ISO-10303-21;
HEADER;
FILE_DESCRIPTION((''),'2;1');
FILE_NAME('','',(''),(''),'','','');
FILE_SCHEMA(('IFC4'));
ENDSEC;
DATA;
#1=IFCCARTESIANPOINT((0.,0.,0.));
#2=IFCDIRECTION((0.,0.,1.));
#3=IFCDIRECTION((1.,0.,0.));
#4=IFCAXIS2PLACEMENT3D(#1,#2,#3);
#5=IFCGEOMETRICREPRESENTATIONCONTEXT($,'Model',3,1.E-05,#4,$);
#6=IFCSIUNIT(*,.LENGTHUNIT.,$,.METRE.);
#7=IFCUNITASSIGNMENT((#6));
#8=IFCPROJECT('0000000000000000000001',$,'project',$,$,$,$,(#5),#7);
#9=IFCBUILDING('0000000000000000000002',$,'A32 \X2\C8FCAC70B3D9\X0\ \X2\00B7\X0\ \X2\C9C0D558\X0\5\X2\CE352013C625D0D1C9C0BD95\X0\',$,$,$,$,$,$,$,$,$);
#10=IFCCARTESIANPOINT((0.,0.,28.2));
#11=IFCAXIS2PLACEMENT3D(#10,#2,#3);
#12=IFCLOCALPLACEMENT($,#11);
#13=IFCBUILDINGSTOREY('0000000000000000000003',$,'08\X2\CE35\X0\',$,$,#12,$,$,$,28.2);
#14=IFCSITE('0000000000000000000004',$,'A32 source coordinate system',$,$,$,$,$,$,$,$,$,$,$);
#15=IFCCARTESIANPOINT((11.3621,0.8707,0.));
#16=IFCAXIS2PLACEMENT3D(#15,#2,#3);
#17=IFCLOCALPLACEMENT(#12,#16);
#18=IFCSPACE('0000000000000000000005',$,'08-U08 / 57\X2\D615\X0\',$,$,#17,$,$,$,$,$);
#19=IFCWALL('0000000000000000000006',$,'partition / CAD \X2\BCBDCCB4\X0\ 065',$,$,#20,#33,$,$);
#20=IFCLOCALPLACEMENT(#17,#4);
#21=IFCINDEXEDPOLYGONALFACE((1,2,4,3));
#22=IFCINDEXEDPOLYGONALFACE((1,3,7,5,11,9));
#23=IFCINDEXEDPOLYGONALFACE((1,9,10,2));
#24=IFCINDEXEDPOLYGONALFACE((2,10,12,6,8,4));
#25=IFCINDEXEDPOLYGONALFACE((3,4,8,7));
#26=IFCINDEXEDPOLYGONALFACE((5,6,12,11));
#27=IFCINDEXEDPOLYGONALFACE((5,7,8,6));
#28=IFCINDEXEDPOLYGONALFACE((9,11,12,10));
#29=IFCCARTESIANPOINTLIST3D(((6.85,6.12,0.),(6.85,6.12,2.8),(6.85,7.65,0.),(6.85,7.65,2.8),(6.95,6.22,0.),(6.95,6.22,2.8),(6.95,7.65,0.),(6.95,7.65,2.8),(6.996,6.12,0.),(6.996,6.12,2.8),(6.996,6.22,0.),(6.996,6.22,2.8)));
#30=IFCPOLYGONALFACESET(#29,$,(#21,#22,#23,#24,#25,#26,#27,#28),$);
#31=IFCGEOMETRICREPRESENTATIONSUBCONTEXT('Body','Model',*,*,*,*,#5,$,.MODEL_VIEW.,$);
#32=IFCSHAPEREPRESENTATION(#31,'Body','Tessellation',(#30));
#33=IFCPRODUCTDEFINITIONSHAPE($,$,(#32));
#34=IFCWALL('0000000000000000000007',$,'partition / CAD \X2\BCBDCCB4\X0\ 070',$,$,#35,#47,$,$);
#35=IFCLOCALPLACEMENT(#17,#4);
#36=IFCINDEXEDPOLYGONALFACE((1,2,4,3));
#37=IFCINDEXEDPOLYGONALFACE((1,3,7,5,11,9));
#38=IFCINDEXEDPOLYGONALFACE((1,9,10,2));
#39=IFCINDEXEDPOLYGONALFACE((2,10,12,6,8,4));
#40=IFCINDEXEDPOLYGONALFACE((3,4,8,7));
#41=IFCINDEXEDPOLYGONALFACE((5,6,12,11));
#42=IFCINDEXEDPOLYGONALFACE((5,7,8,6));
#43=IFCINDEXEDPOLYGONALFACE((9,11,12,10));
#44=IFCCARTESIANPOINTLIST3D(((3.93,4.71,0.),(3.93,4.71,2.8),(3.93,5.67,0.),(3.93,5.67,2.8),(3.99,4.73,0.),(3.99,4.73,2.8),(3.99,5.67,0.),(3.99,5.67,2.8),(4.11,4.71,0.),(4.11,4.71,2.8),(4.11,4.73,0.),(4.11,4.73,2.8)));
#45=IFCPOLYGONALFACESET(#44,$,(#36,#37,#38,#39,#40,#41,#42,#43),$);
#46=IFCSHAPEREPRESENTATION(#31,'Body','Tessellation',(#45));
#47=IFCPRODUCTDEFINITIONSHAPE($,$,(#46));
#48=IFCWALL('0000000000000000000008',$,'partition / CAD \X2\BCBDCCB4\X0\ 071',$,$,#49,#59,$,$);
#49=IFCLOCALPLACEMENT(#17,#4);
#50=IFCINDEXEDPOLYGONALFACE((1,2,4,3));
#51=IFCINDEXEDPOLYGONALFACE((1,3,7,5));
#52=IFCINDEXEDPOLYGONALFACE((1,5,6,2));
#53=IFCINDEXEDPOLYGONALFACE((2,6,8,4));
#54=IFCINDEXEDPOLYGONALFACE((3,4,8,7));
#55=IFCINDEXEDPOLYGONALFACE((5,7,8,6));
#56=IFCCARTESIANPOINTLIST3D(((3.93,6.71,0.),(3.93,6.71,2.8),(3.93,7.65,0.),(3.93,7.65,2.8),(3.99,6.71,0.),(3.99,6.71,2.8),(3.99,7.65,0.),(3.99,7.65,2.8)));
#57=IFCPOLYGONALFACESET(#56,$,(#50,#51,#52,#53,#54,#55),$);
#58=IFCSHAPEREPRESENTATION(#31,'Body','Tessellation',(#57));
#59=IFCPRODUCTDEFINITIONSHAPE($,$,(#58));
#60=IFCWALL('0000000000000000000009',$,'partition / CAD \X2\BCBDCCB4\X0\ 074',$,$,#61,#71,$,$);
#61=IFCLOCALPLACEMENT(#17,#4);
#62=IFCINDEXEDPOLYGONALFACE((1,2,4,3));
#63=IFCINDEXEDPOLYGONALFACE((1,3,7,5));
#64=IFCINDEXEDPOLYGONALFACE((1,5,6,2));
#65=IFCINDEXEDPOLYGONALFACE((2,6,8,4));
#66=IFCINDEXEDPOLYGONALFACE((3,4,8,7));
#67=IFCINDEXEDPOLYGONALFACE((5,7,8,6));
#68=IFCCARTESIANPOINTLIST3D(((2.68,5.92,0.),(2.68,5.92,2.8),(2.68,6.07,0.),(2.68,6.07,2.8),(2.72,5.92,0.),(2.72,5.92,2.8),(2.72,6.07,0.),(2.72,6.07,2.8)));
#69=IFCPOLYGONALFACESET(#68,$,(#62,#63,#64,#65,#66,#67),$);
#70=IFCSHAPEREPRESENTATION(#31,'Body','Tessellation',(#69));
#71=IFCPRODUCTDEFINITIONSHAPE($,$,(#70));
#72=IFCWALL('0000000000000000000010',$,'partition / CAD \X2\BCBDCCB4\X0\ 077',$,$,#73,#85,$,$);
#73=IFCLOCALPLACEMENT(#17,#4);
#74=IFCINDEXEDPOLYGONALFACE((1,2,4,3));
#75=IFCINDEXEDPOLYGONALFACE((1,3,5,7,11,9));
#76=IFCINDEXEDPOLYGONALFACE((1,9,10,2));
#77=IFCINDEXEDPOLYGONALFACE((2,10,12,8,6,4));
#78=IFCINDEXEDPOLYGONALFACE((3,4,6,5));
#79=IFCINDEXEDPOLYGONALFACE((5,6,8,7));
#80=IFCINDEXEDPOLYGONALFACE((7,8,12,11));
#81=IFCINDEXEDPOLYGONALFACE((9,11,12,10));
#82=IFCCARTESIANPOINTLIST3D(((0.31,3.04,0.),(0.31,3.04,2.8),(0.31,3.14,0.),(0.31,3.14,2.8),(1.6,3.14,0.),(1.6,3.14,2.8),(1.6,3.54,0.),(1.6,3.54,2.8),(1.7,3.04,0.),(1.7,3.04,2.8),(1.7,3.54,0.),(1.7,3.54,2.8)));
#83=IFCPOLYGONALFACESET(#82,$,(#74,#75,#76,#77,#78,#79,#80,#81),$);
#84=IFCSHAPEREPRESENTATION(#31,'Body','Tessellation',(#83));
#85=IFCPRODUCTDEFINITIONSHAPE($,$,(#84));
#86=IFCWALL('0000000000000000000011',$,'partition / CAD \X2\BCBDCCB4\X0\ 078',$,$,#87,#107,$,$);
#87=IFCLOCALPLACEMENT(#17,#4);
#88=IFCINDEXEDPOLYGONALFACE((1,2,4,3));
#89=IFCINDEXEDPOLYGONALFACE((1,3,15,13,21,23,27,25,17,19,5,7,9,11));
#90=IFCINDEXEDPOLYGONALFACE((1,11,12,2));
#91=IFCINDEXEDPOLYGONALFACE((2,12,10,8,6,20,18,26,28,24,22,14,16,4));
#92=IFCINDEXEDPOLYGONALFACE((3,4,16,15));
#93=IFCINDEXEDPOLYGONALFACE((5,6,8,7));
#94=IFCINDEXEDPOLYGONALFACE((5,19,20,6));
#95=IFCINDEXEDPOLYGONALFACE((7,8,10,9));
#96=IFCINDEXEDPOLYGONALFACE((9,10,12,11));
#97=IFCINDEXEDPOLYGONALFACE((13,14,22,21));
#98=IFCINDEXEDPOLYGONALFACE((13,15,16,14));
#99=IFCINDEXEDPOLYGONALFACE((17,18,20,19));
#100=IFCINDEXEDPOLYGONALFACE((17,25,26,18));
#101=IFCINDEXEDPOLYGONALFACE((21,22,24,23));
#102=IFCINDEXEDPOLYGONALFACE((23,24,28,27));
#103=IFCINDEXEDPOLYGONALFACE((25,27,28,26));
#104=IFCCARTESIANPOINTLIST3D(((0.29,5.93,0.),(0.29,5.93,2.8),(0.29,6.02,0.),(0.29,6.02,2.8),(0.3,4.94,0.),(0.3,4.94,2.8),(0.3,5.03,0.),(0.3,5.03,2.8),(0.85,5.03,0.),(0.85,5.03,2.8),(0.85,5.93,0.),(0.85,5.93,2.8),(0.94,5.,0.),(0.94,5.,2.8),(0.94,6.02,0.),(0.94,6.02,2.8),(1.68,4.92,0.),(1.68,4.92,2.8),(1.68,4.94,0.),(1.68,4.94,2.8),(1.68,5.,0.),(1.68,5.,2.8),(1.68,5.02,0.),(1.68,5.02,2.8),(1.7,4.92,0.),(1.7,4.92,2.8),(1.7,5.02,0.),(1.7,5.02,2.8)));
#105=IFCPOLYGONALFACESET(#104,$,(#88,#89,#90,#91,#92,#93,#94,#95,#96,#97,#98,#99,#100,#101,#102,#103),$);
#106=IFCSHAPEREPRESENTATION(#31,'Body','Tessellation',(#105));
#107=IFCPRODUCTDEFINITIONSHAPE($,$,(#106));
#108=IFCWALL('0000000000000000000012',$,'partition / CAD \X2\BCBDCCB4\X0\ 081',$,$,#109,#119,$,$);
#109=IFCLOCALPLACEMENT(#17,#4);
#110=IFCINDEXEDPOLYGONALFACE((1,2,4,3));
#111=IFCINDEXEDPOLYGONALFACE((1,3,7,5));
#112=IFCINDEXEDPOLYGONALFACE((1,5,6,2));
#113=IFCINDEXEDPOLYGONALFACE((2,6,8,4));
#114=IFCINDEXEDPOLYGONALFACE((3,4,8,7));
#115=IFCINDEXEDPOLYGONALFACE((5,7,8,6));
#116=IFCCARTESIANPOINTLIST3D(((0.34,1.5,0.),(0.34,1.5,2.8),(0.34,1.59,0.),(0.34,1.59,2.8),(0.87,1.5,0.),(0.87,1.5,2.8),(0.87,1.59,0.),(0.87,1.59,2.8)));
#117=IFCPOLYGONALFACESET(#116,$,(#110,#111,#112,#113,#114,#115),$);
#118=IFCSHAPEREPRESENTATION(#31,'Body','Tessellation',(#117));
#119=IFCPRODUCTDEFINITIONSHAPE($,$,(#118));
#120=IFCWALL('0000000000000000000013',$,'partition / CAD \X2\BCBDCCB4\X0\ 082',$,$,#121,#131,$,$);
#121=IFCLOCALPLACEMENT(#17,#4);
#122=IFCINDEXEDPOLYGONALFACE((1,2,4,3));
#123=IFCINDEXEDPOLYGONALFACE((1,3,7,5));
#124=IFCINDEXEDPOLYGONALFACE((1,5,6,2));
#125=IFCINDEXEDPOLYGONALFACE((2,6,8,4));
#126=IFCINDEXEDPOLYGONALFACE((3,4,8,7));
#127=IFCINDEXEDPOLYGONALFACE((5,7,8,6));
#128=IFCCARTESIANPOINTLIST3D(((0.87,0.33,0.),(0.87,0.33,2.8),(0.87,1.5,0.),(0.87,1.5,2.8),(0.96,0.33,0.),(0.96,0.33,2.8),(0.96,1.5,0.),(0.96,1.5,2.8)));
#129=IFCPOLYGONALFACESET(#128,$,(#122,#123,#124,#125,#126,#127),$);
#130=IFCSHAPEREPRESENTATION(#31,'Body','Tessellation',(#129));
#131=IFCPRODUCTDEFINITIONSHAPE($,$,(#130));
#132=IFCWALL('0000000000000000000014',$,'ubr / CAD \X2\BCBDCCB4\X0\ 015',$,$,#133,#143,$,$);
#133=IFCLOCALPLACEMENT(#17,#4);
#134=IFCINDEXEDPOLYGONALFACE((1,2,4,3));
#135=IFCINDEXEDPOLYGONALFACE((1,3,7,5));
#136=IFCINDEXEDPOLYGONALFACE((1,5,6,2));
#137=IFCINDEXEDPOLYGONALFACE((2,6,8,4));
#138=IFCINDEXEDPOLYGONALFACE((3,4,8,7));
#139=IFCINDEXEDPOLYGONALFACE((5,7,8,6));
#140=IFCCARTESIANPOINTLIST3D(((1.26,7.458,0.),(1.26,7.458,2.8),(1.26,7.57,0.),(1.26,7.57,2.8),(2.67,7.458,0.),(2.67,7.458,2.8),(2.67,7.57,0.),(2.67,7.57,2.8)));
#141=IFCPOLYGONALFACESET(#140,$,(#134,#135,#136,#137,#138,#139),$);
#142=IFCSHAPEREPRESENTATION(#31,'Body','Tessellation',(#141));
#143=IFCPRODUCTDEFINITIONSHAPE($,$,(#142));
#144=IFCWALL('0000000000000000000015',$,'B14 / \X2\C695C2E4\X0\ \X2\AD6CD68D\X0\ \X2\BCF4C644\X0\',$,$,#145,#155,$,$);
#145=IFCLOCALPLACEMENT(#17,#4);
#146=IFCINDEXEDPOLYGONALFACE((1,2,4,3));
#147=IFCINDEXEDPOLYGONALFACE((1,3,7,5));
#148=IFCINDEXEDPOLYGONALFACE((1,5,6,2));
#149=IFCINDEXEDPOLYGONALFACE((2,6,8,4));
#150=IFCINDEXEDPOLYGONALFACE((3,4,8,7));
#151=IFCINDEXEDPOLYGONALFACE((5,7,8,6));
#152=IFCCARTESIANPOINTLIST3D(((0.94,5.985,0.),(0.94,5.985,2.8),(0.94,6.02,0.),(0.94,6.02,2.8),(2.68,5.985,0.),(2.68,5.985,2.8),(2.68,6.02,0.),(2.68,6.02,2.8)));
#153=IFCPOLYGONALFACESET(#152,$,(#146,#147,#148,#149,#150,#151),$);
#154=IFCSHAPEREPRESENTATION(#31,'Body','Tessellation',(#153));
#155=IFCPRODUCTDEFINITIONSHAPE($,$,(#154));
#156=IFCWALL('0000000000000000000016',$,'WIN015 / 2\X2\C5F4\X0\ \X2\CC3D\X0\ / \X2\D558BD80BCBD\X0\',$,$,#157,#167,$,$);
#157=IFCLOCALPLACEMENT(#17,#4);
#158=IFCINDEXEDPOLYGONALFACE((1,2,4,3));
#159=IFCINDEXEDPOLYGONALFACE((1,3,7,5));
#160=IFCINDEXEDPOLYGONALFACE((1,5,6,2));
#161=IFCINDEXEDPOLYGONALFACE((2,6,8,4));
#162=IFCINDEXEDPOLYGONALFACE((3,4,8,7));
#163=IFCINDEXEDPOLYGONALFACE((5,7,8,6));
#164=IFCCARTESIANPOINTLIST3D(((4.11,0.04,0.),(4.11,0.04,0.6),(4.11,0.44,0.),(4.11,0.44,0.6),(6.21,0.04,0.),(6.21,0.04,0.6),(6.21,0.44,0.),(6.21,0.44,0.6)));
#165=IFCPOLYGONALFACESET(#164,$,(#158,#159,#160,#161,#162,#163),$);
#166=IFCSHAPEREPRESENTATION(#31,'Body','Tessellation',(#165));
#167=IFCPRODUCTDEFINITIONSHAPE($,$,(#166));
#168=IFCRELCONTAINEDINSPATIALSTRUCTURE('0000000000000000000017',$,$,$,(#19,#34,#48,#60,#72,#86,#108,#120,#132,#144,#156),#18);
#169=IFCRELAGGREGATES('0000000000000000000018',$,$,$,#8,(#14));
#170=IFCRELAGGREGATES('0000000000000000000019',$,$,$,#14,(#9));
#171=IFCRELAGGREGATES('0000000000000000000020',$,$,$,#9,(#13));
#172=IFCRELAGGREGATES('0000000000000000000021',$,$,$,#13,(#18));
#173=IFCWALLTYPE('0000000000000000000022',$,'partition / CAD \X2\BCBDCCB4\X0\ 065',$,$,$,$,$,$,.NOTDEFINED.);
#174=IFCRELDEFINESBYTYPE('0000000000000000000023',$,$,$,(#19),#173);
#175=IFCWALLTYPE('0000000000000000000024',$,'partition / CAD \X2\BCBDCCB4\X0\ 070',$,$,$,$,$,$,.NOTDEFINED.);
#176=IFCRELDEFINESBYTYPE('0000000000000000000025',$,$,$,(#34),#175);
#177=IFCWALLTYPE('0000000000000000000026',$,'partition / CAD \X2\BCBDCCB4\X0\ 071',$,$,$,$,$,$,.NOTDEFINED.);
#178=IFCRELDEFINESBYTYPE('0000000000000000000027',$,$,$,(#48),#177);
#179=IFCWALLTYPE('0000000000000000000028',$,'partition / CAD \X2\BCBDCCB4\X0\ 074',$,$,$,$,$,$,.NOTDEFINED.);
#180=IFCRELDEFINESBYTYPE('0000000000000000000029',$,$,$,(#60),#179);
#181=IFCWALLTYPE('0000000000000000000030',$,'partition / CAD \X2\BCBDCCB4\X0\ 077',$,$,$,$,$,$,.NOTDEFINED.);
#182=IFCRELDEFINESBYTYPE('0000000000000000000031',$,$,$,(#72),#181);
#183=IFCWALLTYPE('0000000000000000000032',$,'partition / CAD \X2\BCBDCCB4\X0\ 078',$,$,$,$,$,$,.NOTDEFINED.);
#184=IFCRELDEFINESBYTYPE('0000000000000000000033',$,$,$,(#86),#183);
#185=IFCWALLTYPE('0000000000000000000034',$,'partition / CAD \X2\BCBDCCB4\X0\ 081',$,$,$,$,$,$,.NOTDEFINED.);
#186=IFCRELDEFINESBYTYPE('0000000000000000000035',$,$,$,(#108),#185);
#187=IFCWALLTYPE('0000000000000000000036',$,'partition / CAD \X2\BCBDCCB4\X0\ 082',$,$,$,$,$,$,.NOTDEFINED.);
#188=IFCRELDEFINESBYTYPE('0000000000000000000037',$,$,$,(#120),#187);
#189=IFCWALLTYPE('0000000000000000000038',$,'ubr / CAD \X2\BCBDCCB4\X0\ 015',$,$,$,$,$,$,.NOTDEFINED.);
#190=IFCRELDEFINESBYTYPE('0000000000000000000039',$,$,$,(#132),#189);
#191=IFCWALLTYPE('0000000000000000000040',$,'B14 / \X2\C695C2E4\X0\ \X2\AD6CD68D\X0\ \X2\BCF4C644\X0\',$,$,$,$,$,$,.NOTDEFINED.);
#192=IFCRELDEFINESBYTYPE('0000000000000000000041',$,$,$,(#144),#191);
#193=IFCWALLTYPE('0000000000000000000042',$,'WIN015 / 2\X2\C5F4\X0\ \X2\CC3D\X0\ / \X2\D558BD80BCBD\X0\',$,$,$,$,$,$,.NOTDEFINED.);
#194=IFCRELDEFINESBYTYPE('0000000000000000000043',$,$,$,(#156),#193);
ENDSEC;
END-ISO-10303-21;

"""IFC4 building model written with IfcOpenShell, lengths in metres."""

from ifc_helpers import new_model, si_unit, frame, origin, origin_with_axes, place, context, subcontext, project, spatial, polyline, outline, extrude, source, transform, mapped, type_object, type_shapes, element, save


model = new_model("IFC4")

# Units and contexts
model_context = context("Model", 3, precision=1e-05, world=origin_with_axes())
body_context = subcontext(model_context, "Body", "Model", "MODEL_VIEW")
ifc_project = project(units=[si_unit("LENGTHUNIT", "METRE")], contexts=[model_context])

# Site, building, storey, space
storey_placement = place(None, frame((0.0, 0.0, 28.2), z_axis=(0.0, 0.0, 1.0), x_axis=(1.0, 0.0, 0.0)))
space_placement = place(storey_placement, frame((11.3621, 0.8707, 0.0), z_axis=(0.0, 0.0, 1.0), x_axis=(1.0, 0.0, 0.0)))
site = spatial("IfcSite", under=ifc_project, Name="A32 source coordinate system")
building = spatial("IfcBuilding", under=site, Name="A32 주거동 · 지하5층–옥탑지붕")
storey = spatial("IfcBuildingStorey", under=building, at=storey_placement, Name="08층", Elevation=28.2)
space = spatial("IfcSpace", under=storey, at=space_placement, Name="08-U08 / 57형")

# Walls
wall_type_1 = type_object("IfcWallType", Name="partition / CAD 벽체 065", PredefinedType="NOTDEFINED")
shared_shape_1 = source(origin(), body_context, "Body", "SweptSolid", [
    extrude(outline(polyline([(6.95, 7.65), (6.95, 6.22), (6.996, 6.22), (6.996, 6.12), (6.85, 6.12), (6.85, 7.65), (6.95, 7.65)])), origin(), (0.0, 0.0, 1.0), 2.8),
])
type_shapes(wall_type_1, [shared_shape_1])
wall_1_placement = place(space_placement, origin_with_axes())
element("IfcWall", 1, at=wall_1_placement, inside=space, type_object=wall_type_1, Name="partition / CAD 벽체 065", context=body_context, shape_type="MappedRepresentation", body=[
    mapped(shared_shape_1, transform((0.0, 0.0, 0.0), scale=1.0)),
])
wall_type_2 = type_object("IfcWallType", Name="partition / CAD 벽체 070", PredefinedType="NOTDEFINED")
shared_shape_2 = source(origin(), body_context, "Body", "SweptSolid", [
    extrude(outline(polyline([(4.11, 4.73), (4.11, 4.71), (3.93, 4.71), (3.93, 5.67), (3.99, 5.67), (3.99, 4.73), (4.11, 4.73)])), origin(), (0.0, 0.0, 1.0), 2.8),
])
type_shapes(wall_type_2, [shared_shape_2])
wall_2_placement = place(space_placement, origin_with_axes())
element("IfcWall", 2, at=wall_2_placement, inside=space, type_object=wall_type_2, Name="partition / CAD 벽체 070", context=body_context, shape_type="MappedRepresentation", body=[
    mapped(shared_shape_2, transform((0.0, 0.0, 0.0), scale=1.0)),
])
wall_type_3 = type_object("IfcWallType", Name="partition / CAD 벽체 071", PredefinedType="NOTDEFINED")
shared_shape_3 = source(origin(), body_context, "Body", "SweptSolid", [
    extrude(outline(polyline([(3.93, 6.71), (3.93, 7.65), (3.99, 7.65), (3.99, 6.71), (3.93, 6.71)])), origin(), (0.0, 0.0, 1.0), 2.8),
])
type_shapes(wall_type_3, [shared_shape_3])
wall_3_placement = place(space_placement, origin_with_axes())
element("IfcWall", 3, at=wall_3_placement, inside=space, type_object=wall_type_3, Name="partition / CAD 벽체 071", context=body_context, shape_type="MappedRepresentation", body=[
    mapped(shared_shape_3, transform((0.0, 0.0, 0.0), scale=1.0)),
])
wall_type_4 = type_object("IfcWallType", Name="partition / CAD 벽체 074", PredefinedType="NOTDEFINED")
shared_shape_4 = source(origin(), body_context, "Body", "SweptSolid", [
    extrude(outline(polyline([(2.72, 6.07), (2.72, 5.92), (2.68, 5.92), (2.68, 6.07), (2.72, 6.07)])), origin(), (0.0, 0.0, 1.0), 2.8),
])
type_shapes(wall_type_4, [shared_shape_4])
wall_4_placement = place(space_placement, origin_with_axes())
element("IfcWall", 4, at=wall_4_placement, inside=space, type_object=wall_type_4, Name="partition / CAD 벽체 074", context=body_context, shape_type="MappedRepresentation", body=[
    mapped(shared_shape_4, transform((0.0, 0.0, 0.0), scale=1.0)),
])
wall_type_5 = type_object("IfcWallType", Name="partition / CAD 벽체 077", PredefinedType="NOTDEFINED")
shared_shape_5 = source(origin(), body_context, "Body", "SweptSolid", [
    extrude(outline(polyline([(1.7, 3.54), (1.7, 3.04), (0.31, 3.04), (0.31, 3.14), (1.6, 3.14), (1.6, 3.54), (1.7, 3.54)])), origin(), (0.0, 0.0, 1.0), 2.8),
])
type_shapes(wall_type_5, [shared_shape_5])
wall_5_placement = place(space_placement, origin_with_axes())
element("IfcWall", 5, at=wall_5_placement, inside=space, type_object=wall_type_5, Name="partition / CAD 벽체 077", context=body_context, shape_type="MappedRepresentation", body=[
    mapped(shared_shape_5, transform((0.0, 0.0, 0.0), scale=1.0)),
])
wall_type_6 = type_object("IfcWallType", Name="partition / CAD 벽체 078", PredefinedType="NOTDEFINED")
shared_shape_6 = source(origin(), body_context, "Body", "SweptSolid", [
    extrude(outline(polyline([(1.7, 4.92), (1.68, 4.92), (1.68, 4.94), (0.3, 4.94), (0.3, 5.03), (0.85, 5.03), (0.85, 5.93), (0.29, 5.93), (0.29, 6.02), (0.94, 6.02), (0.94, 5.0), (1.68, 5.0), (1.68, 5.02), (1.7, 5.02), (1.7, 4.92)])), origin(), (0.0, 0.0, 1.0), 2.8),
])
type_shapes(wall_type_6, [shared_shape_6])
wall_6_placement = place(space_placement, origin_with_axes())
element("IfcWall", 6, at=wall_6_placement, inside=space, type_object=wall_type_6, Name="partition / CAD 벽체 078", context=body_context, shape_type="MappedRepresentation", body=[
    mapped(shared_shape_6, transform((0.0, 0.0, 0.0), scale=1.0)),
])
wall_type_7 = type_object("IfcWallType", Name="partition / CAD 벽체 081", PredefinedType="NOTDEFINED")
shared_shape_7 = source(origin(), body_context, "Body", "SweptSolid", [
    extrude(outline(polyline([(0.34, 1.59), (0.87, 1.59), (0.87, 1.5), (0.34, 1.5), (0.34, 1.59)])), origin(), (0.0, 0.0, 1.0), 2.8),
])
type_shapes(wall_type_7, [shared_shape_7])
wall_7_placement = place(space_placement, origin_with_axes())
element("IfcWall", 7, at=wall_7_placement, inside=space, type_object=wall_type_7, Name="partition / CAD 벽체 081", context=body_context, shape_type="MappedRepresentation", body=[
    mapped(shared_shape_7, transform((0.0, 0.0, 0.0), scale=1.0)),
])
wall_type_8 = type_object("IfcWallType", Name="partition / CAD 벽체 082", PredefinedType="NOTDEFINED")
shared_shape_8 = source(origin(), body_context, "Body", "SweptSolid", [
    extrude(outline(polyline([(0.96, 0.33), (0.87, 0.33), (0.87, 1.5), (0.96, 1.5), (0.96, 0.33)])), origin(), (0.0, 0.0, 1.0), 2.8),
])
type_shapes(wall_type_8, [shared_shape_8])
wall_8_placement = place(space_placement, origin_with_axes())
element("IfcWall", 8, at=wall_8_placement, inside=space, type_object=wall_type_8, Name="partition / CAD 벽체 082", context=body_context, shape_type="MappedRepresentation", body=[
    mapped(shared_shape_8, transform((0.0, 0.0, 0.0), scale=1.0)),
])
wall_type_9 = type_object("IfcWallType", Name="ubr / CAD 벽체 015", PredefinedType="NOTDEFINED")
shared_shape_9 = source(origin(), body_context, "Body", "SweptSolid", [
    extrude(outline(polyline([(2.67, 7.57), (2.67, 7.458), (1.26, 7.458), (1.26, 7.57), (2.67, 7.57)])), origin(), (0.0, 0.0, 1.0), 2.8),
])
type_shapes(wall_type_9, [shared_shape_9])
wall_9_placement = place(space_placement, origin_with_axes())
element("IfcWall", 9, at=wall_9_placement, inside=space, type_object=wall_type_9, Name="ubr / CAD 벽체 015", context=body_context, shape_type="MappedRepresentation", body=[
    mapped(shared_shape_9, transform((0.0, 0.0, 0.0), scale=1.0)),
])
wall_type_10 = type_object("IfcWallType", Name="B14 / 욕실 구획 보완", PredefinedType="NOTDEFINED")
shared_shape_10 = source(origin(), body_context, "Body", "SweptSolid", [
    extrude(outline(polyline([(2.68, 5.985), (0.94, 5.985), (0.94, 6.02), (2.68, 6.02), (2.68, 5.985)])), origin(), (0.0, 0.0, 1.0), 2.8),
])
type_shapes(wall_type_10, [shared_shape_10])
wall_10_placement = place(space_placement, origin_with_axes())
element("IfcWall", 10, at=wall_10_placement, inside=space, type_object=wall_type_10, Name="B14 / 욕실 구획 보완", context=body_context, shape_type="MappedRepresentation", body=[
    mapped(shared_shape_10, transform((0.0, 0.0, 0.0), scale=1.0)),
])
wall_type_11 = type_object("IfcWallType", Name="WIN015 / 2열 창 / 하부벽", PredefinedType="NOTDEFINED")
shared_shape_11 = source(origin(), body_context, "Body", "SweptSolid", [
    extrude(outline(polyline([(4.11, 0.04), (4.11, 0.44), (6.21, 0.44), (6.21, 0.04), (4.11, 0.04)])), origin(), (0.0, 0.0, 1.0), 0.6),
])
type_shapes(wall_type_11, [shared_shape_11])
wall_11_placement = place(space_placement, origin_with_axes())
element("IfcWall", 11, at=wall_11_placement, inside=space, type_object=wall_type_11, Name="WIN015 / 2열 창 / 하부벽", context=body_context, shape_type="MappedRepresentation", body=[
    mapped(shared_shape_11, transform((0.0, 0.0, 0.0), scale=1.0)),
])

save(model, "model.ifc")
